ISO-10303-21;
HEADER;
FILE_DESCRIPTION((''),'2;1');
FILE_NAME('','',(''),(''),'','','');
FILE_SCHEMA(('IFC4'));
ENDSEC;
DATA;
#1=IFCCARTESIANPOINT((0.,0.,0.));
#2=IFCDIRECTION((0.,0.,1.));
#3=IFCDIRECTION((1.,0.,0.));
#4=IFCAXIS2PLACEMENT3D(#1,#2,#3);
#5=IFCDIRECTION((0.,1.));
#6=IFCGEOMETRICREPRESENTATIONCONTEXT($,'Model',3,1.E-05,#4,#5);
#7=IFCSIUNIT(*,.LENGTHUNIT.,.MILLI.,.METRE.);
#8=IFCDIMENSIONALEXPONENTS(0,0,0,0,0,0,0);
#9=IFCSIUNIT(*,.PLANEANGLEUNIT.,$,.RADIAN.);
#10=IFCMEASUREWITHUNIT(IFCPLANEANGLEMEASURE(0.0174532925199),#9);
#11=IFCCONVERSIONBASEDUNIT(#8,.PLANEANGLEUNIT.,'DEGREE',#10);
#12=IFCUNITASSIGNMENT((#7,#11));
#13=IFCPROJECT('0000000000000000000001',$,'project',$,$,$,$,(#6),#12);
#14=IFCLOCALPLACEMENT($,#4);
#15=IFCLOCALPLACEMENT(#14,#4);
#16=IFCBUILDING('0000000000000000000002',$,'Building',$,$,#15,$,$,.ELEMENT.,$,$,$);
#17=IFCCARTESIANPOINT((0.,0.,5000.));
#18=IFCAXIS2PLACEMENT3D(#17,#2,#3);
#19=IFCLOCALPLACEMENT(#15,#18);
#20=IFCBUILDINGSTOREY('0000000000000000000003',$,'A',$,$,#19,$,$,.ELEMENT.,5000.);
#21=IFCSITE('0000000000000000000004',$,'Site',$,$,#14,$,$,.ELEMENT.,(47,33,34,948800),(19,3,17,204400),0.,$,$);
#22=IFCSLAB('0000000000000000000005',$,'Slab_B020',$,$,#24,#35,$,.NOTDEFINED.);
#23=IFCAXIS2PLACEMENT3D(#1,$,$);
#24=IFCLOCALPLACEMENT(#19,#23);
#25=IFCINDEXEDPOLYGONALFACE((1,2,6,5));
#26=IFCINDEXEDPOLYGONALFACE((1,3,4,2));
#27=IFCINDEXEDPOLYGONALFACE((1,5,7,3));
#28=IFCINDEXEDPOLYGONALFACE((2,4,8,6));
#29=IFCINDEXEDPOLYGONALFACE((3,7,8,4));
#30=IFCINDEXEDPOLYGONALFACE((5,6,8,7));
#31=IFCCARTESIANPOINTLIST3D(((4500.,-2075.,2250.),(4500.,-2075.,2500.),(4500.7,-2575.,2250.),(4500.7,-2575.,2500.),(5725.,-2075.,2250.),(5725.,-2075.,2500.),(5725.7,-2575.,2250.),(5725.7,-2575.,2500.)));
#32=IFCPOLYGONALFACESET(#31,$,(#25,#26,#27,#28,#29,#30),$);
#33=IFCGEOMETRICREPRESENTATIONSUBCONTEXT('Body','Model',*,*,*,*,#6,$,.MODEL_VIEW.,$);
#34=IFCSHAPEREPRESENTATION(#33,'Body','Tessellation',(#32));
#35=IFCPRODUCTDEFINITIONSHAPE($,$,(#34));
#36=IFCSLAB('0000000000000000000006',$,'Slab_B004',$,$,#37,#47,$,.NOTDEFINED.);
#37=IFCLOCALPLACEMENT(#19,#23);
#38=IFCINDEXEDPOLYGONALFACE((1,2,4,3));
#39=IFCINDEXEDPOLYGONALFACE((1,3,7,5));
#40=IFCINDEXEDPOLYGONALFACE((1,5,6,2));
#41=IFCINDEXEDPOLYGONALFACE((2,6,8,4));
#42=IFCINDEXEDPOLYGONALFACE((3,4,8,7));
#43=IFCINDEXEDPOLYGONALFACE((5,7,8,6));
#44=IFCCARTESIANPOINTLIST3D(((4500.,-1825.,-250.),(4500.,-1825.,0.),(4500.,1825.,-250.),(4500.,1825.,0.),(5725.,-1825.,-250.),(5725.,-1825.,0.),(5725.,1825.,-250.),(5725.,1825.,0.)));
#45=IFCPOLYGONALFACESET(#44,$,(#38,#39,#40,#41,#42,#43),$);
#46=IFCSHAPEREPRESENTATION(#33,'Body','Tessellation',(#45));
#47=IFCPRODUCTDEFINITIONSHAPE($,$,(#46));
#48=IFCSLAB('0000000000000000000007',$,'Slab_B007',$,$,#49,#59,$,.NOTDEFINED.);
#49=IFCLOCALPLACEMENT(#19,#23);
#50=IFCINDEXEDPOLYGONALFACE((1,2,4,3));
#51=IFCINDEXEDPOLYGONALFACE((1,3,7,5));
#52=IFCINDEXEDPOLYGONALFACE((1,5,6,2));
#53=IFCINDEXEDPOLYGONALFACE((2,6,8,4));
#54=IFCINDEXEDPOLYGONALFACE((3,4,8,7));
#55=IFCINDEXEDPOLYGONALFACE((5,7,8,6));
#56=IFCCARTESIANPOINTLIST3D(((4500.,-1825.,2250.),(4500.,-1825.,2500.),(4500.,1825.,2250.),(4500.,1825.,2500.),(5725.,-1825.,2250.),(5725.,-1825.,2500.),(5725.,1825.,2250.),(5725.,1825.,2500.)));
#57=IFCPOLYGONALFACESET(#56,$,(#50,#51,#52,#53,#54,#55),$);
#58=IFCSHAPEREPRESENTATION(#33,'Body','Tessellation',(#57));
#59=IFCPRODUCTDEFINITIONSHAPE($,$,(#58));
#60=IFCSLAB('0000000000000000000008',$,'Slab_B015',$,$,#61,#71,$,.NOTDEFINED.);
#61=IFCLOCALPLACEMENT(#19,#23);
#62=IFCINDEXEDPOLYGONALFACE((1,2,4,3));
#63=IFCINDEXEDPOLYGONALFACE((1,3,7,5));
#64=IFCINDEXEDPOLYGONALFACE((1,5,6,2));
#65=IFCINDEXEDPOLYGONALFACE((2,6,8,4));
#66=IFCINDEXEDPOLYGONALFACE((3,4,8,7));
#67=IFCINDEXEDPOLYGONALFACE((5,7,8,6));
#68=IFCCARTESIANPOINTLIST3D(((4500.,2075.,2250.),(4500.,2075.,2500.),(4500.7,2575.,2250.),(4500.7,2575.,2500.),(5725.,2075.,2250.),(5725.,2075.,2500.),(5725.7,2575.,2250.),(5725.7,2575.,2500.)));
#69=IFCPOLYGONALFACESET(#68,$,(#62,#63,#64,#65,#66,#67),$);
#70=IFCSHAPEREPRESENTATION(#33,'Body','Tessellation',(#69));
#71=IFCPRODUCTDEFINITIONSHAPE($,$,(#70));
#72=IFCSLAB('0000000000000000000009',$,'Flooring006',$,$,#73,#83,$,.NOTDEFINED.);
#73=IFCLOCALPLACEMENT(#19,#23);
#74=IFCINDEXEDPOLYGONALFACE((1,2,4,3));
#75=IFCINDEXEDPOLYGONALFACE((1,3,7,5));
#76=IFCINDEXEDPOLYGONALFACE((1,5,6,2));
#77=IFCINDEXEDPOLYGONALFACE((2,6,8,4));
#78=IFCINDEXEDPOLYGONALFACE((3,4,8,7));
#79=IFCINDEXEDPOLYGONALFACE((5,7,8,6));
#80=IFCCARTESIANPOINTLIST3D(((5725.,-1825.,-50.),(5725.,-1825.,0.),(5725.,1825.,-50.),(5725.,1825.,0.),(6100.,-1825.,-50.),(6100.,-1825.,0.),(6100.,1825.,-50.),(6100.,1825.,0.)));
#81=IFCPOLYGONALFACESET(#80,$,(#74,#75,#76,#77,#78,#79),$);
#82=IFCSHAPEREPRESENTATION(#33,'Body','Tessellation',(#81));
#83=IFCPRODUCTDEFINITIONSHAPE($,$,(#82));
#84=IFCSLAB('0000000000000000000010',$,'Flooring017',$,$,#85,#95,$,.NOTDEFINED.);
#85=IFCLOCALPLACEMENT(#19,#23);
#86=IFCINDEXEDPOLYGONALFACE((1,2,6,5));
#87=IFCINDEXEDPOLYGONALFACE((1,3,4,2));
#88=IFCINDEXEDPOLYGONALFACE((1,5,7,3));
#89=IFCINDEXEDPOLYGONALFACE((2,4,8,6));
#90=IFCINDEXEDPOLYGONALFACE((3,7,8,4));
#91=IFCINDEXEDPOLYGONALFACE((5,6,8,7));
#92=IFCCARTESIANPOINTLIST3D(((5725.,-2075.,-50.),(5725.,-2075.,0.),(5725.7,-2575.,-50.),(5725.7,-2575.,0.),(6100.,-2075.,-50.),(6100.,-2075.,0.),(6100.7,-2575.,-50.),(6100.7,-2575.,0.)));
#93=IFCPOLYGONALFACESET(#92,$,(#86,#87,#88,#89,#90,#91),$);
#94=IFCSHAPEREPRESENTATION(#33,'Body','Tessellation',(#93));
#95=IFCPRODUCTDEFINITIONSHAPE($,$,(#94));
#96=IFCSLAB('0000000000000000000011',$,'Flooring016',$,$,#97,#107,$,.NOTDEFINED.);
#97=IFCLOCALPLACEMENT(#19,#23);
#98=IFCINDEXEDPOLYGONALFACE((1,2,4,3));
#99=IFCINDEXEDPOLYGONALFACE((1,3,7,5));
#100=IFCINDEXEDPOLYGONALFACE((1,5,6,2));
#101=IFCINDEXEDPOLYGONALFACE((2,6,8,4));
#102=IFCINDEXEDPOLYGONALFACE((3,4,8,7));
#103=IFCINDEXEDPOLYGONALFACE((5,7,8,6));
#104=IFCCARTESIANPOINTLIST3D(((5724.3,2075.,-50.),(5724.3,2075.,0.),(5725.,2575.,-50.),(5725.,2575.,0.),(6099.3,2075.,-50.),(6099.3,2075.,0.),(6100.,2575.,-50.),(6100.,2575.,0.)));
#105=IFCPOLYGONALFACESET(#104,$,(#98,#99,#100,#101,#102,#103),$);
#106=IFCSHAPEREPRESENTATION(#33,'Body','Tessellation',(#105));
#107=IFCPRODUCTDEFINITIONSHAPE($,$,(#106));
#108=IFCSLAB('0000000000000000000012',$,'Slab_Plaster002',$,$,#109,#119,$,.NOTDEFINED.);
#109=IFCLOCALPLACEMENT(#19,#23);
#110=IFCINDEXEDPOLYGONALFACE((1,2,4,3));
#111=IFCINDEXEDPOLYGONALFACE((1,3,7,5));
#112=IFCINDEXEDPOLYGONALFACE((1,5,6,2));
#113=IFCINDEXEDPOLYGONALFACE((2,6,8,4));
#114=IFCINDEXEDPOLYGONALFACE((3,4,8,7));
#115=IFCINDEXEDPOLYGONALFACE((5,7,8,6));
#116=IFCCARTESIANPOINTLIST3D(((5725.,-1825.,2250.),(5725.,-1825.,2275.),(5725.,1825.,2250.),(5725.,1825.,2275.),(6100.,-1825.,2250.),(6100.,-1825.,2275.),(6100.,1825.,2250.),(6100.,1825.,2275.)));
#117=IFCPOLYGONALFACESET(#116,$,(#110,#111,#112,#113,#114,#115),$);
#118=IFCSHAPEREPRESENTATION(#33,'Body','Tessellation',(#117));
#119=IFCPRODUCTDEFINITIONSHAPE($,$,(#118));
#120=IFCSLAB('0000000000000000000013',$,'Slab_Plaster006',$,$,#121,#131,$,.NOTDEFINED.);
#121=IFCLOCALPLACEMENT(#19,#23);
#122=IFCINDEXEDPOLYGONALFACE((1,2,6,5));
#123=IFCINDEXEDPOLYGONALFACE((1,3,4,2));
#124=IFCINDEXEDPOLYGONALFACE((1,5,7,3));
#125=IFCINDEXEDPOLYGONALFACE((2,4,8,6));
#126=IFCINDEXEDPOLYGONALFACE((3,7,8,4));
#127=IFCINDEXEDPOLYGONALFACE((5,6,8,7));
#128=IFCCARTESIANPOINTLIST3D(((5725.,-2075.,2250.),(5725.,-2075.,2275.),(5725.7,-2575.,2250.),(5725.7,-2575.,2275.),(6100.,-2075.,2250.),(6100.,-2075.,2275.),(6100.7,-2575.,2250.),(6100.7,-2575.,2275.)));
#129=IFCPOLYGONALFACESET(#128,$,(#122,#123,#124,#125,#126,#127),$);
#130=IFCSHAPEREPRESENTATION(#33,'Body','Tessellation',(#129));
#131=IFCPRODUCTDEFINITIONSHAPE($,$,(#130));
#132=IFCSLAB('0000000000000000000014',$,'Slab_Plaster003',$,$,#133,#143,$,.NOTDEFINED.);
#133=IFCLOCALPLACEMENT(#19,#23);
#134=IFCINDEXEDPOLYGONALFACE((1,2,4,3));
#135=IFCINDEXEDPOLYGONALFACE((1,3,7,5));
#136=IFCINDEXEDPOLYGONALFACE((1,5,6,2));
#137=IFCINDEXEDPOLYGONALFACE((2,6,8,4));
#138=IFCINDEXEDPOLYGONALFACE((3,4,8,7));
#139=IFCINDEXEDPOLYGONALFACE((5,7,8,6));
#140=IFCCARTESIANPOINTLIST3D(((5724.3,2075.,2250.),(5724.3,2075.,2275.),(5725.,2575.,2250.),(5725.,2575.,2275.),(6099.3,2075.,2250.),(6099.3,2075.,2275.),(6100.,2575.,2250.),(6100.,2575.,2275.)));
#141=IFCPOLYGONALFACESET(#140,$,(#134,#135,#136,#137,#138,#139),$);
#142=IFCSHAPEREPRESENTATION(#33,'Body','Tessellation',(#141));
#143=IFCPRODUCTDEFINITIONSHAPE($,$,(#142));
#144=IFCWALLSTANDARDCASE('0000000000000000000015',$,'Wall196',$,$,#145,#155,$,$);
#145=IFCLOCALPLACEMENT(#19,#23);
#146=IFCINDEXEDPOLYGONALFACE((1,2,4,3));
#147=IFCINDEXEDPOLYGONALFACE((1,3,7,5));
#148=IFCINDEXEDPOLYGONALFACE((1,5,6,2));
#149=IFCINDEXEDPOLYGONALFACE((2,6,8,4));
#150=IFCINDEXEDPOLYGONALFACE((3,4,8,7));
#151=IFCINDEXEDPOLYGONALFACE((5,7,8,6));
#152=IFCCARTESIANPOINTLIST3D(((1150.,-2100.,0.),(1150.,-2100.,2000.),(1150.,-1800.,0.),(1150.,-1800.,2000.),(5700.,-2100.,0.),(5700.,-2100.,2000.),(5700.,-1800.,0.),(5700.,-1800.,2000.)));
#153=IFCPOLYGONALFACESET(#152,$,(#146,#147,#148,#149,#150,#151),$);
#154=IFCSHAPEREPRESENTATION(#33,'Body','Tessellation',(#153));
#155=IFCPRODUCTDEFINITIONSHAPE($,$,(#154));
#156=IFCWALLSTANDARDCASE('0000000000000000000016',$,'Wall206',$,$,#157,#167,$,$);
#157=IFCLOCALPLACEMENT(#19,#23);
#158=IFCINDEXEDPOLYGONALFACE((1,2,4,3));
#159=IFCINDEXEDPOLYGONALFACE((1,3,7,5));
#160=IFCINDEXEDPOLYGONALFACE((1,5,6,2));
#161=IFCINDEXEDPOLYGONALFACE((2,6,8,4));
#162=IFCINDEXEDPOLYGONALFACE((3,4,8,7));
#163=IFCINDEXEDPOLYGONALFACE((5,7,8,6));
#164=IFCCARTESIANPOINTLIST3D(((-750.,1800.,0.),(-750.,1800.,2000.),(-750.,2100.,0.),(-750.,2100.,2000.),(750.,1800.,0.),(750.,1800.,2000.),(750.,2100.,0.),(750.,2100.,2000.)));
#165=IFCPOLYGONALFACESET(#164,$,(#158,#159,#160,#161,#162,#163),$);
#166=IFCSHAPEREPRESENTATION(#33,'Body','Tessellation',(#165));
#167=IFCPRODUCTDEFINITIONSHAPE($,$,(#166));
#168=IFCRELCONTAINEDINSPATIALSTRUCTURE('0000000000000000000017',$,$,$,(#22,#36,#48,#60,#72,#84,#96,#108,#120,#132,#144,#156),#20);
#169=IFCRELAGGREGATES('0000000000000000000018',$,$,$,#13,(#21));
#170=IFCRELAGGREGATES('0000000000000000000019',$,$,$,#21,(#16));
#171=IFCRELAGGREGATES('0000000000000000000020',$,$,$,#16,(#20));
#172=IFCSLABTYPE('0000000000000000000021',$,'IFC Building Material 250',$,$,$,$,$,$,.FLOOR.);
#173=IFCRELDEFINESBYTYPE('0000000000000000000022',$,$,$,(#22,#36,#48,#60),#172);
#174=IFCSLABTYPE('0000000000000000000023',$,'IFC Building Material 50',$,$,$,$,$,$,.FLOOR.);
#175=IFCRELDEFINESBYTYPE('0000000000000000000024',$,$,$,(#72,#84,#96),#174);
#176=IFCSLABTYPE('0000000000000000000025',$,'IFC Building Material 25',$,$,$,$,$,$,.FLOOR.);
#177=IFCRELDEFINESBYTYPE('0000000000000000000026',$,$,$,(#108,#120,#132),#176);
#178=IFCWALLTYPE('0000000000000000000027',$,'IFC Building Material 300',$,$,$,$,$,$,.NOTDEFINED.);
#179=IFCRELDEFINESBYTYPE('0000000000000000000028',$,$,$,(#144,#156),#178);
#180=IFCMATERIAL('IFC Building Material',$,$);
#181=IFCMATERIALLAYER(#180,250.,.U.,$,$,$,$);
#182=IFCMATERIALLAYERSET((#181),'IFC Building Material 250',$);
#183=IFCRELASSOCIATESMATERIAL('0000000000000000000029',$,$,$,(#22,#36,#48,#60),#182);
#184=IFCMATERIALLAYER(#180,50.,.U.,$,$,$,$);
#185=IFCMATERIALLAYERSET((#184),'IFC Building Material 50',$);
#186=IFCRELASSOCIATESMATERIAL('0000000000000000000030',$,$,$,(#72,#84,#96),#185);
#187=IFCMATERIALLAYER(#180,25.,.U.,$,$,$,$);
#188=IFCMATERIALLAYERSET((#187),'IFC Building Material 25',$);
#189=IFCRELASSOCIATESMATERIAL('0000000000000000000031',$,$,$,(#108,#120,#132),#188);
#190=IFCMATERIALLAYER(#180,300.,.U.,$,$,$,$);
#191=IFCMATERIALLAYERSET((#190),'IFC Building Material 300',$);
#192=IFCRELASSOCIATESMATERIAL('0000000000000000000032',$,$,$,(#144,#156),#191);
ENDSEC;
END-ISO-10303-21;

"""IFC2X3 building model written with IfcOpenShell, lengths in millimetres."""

from ifc_helpers import new_model, entity, si_unit, converted_unit, direction, frame, origin_with_axes, place, context, subcontext, project, spatial, polyline, outline, extrude, material, layer, layer_set, layer_usage, type_object, element, save


model = new_model("IFC2X3")

# Units and contexts
model_context = context("Model", 3, precision=1e-05, world=origin_with_axes(), true_north=direction((0.0, 1.0)))
body_context = subcontext(model_context, "Body", "Model", "MODEL_VIEW")
ifc_project = project(units=[si_unit("LENGTHUNIT", "METRE", prefix="MILLI"), converted_unit("PLANEANGLEUNIT", "DEGREE", entity("IfcPlaneAngleMeasure", 0.0174532925199), si_unit("PLANEANGLEUNIT", "RADIAN"), dimensions=[0, 0, 0, 0, 0, 0, 0])], contexts=[model_context])

# Site, building, storey
site_placement = place(None, origin_with_axes())
site = spatial("IfcSite", under=ifc_project, at=site_placement, Name="Site", CompositionType="ELEMENT", RefLatitude=(47, 33, 34, 948800), RefLongitude=(19, 3, 17, 204400), RefElevation=0.0)
building_placement = place(site_placement, origin_with_axes())
building = spatial("IfcBuilding", under=site, at=building_placement, Name="Building", CompositionType="ELEMENT")
storey_placement = place(building_placement, frame((0.0, 0.0, 5000.0), z_axis=(0.0, 0.0, 1.0), x_axis=(1.0, 0.0, 0.0)))
storey = spatial("IfcBuildingStorey", under=building, at=storey_placement, Name="A", CompositionType="ELEMENT", Elevation=5000.0)

# Shared definitions
ifc_material = material(Name="IFC Building Material")

# Slabs
ifc_layer_1 = layer(ifc_material, 250.0, ventilated="UNKNOWN")
ifc_layer_set_1 = layer_set([ifc_layer_1], Name="IFC Building Material 250")
slab_type_1 = type_object("IfcSlabType", Name="IFC Building Material 250", PredefinedType="FLOOR")
ifc_layer_usage_1 = layer_usage(ifc_layer_set_1, "AXIS3", "NEGATIVE", 250.0)
slab_1_placement = place(storey_placement, frame((4500.0, -2075.0, 2500.0), z_axis=(0.0, 0.0, 1.0), x_axis=(1.0, 0.0, 0.0)))
element("IfcSlab", 1, at=slab_1_placement, inside=storey, type_object=slab_type_1, material=ifc_layer_usage_1, Name="Slab_B020", PredefinedType="NOTDEFINED", context=body_context, shape_type="SweptSolid", body=[
    extrude(outline(polyline([(0.0, 0.0), (0.7, -500.0), (1225.7, -500.0), (1225.0, 0.0), (0.0, 0.0)])), frame((0.0, 0.0, -250.0), z_axis=(0.0, 0.0, 1.0), x_axis=(1.0, 0.0, 0.0)), (0.0, 0.0, 1.0), 250.0),
])
ifc_layer_usage_2 = layer_usage(ifc_layer_set_1, "AXIS3", "NEGATIVE", 250.0)
slab_2_placement = place(storey_placement, frame((4500.0, 1825.0, 0.0), z_axis=(0.0, 0.0, 1.0), x_axis=(1.0, 0.0, 0.0)))
element("IfcSlab", 2, at=slab_2_placement, inside=storey, type_object=slab_type_1, material=ifc_layer_usage_2, Name="Slab_B004", PredefinedType="NOTDEFINED", context=body_context, shape_type="SweptSolid", body=[
    extrude(outline(polyline([(0.0, 0.0), (0.0, -3650.0), (1225.0, -3650.0), (1225.0, 0.0), (0.0, 0.0)])), frame((0.0, 0.0, -250.0), z_axis=(0.0, 0.0, 1.0), x_axis=(1.0, 0.0, 0.0)), (0.0, 0.0, 1.0), 250.0),
])
ifc_layer_usage_3 = layer_usage(ifc_layer_set_1, "AXIS3", "NEGATIVE", 250.0)
slab_3_placement = place(storey_placement, frame((4500.0, 1825.0, 2500.0), z_axis=(0.0, 0.0, 1.0), x_axis=(1.0, 0.0, 0.0)))
element("IfcSlab", 3, at=slab_3_placement, inside=storey, type_object=slab_type_1, material=ifc_layer_usage_3, Name="Slab_B007", PredefinedType="NOTDEFINED", context=body_context, shape_type="SweptSolid", body=[
    extrude(outline(polyline([(0.0, 0.0), (0.0, -3650.0), (1225.0, -3650.0), (1225.0, 0.0), (0.0, 0.0)])), frame((0.0, 0.0, -250.0), z_axis=(0.0, 0.0, 1.0), x_axis=(1.0, 0.0, 0.0)), (0.0, 0.0, 1.0), 250.0),
])
ifc_layer_usage_4 = layer_usage(ifc_layer_set_1, "AXIS3", "NEGATIVE", 250.0)
slab_4_placement = place(storey_placement, frame((4500.0, 2075.0, 2500.0), z_axis=(0.0, 0.0, 1.0), x_axis=(1.0, 0.0, 0.0)))
element("IfcSlab", 4, at=slab_4_placement, inside=storey, type_object=slab_type_1, material=ifc_layer_usage_4, Name="Slab_B015", PredefinedType="NOTDEFINED", context=body_context, shape_type="SweptSolid", body=[
    extrude(outline(polyline([(0.0, 0.0), (1225.0, 0.0), (1225.7, 500.0), (0.7, 500.0), (0.0, 0.0)])), frame((0.0, 0.0, -250.0), z_axis=(0.0, 0.0, 1.0), x_axis=(1.0, 0.0, 0.0)), (0.0, 0.0, 1.0), 250.0),
])
ifc_layer_2 = layer(ifc_material, 50.0, ventilated="UNKNOWN")
ifc_layer_set_2 = layer_set([ifc_layer_2], Name="IFC Building Material 50")
ifc_layer_usage_5 = layer_usage(ifc_layer_set_2, "AXIS3", "NEGATIVE", 50.0)
slab_type_2 = type_object("IfcSlabType", Name="IFC Building Material 50", PredefinedType="FLOOR")
slab_5_placement = place(storey_placement, frame((5725.0, -1825.0, 0.0), z_axis=(0.0, 0.0, 1.0), x_axis=(1.0, 0.0, 0.0)))
element("IfcSlab", 5, at=slab_5_placement, inside=storey, type_object=slab_type_2, material=ifc_layer_usage_5, Name="Flooring006", PredefinedType="NOTDEFINED", context=body_context, shape_type="SweptSolid", body=[
    extrude(outline(polyline([(0.0, 0.0), (375.0, 0.0), (375.0, 3650.0), (0.0, 3650.0), (0.0, 0.0)])), frame((0.0, 0.0, -50.0), z_axis=(0.0, 0.0, 1.0), x_axis=(1.0, 0.0, 0.0)), (0.0, 0.0, 1.0), 50.0),
])
ifc_layer_usage_6 = layer_usage(ifc_layer_set_2, "AXIS3", "NEGATIVE", 50.0)
slab_6_placement = place(storey_placement, frame((5725.7, -2575.0, 0.0), z_axis=(0.0, 0.0, 1.0), x_axis=(1.0, 0.0, 0.0)))
element("IfcSlab", 6, at=slab_6_placement, inside=storey, type_object=slab_type_2, material=ifc_layer_usage_6, Name="Flooring017", PredefinedType="NOTDEFINED", context=body_context, shape_type="SweptSolid", body=[
    extrude(outline(polyline([(0.0, 0.0), (375.0, 0.0), (374.3, 500.0), (-0.7, 500.0), (0.0, 0.0)])), frame((0.0, 0.0, -50.0), z_axis=(0.0, 0.0, 1.0), x_axis=(1.0, 0.0, 0.0)), (0.0, 0.0, 1.0), 50.0),
])
ifc_layer_usage_7 = layer_usage(ifc_layer_set_2, "AXIS3", "NEGATIVE", 50.0)
slab_7_placement = place(storey_placement, frame((5725.0, 2575.0, 0.0), z_axis=(0.0, 0.0, 1.0), x_axis=(1.0, 0.0, 0.0)))
element("IfcSlab", 7, at=slab_7_placement, inside=storey, type_object=slab_type_2, material=ifc_layer_usage_7, Name="Flooring016", PredefinedType="NOTDEFINED", context=body_context, shape_type="SweptSolid", body=[
    extrude(outline(polyline([(0.0, 0.0), (-0.7, -500.0), (374.3, -500.0), (375.0, 0.0), (0.0, 0.0)])), frame((0.0, 0.0, -50.0), z_axis=(0.0, 0.0, 1.0), x_axis=(1.0, 0.0, 0.0)), (0.0, 0.0, 1.0), 50.0),
])
ifc_layer_3 = layer(ifc_material, 25.0, ventilated="UNKNOWN")
ifc_layer_set_3 = layer_set([ifc_layer_3], Name="IFC Building Material 25")
ifc_layer_usage_8 = layer_usage(ifc_layer_set_3, "AXIS3", "NEGATIVE", 25.0)
slab_type_3 = type_object("IfcSlabType", Name="IFC Building Material 25", PredefinedType="FLOOR")
slab_8_placement = place(storey_placement, frame((5725.0, -1825.0, 2275.0), z_axis=(0.0, 0.0, 1.0), x_axis=(1.0, 0.0, 0.0)))
element("IfcSlab", 8, at=slab_8_placement, inside=storey, type_object=slab_type_3, material=ifc_layer_usage_8, Name="Slab_Plaster002", PredefinedType="NOTDEFINED", context=body_context, shape_type="SweptSolid", body=[
    extrude(outline(polyline([(0.0, 0.0), (375.0, 0.0), (375.0, 3650.0), (0.0, 3650.0), (0.0, 0.0)])), frame((0.0, 0.0, -25.0), z_axis=(0.0, 0.0, 1.0), x_axis=(1.0, 0.0, 0.0)), (0.0, 0.0, 1.0), 25.0),
])
ifc_layer_usage_9 = layer_usage(ifc_layer_set_3, "AXIS3", "NEGATIVE", 25.0)
slab_9_placement = place(storey_placement, frame((5725.7, -2575.0, 2275.0), z_axis=(0.0, 0.0, 1.0), x_axis=(1.0, 0.0, 0.0)))
element("IfcSlab", 9, at=slab_9_placement, inside=storey, type_object=slab_type_3, material=ifc_layer_usage_9, Name="Slab_Plaster006", PredefinedType="NOTDEFINED", context=body_context, shape_type="SweptSolid", body=[
    extrude(outline(polyline([(0.0, 0.0), (375.0, 0.0), (374.3, 500.0), (-0.7, 500.0), (0.0, 0.0)])), frame((0.0, 0.0, -25.0), z_axis=(0.0, 0.0, 1.0), x_axis=(1.0, 0.0, 0.0)), (0.0, 0.0, 1.0), 25.0),
])
ifc_layer_usage_10 = layer_usage(ifc_layer_set_3, "AXIS3", "NEGATIVE", 25.0)
slab_10_placement = place(storey_placement, frame((5725.0, 2575.0, 2275.0), z_axis=(0.0, 0.0, 1.0), x_axis=(1.0, 0.0, 0.0)))
element("IfcSlab", 10, at=slab_10_placement, inside=storey, type_object=slab_type_3, material=ifc_layer_usage_10, Name="Slab_Plaster003", PredefinedType="NOTDEFINED", context=body_context, shape_type="SweptSolid", body=[
    extrude(outline(polyline([(0.0, 0.0), (-0.7, -500.0), (374.3, -500.0), (375.0, 0.0), (0.0, 0.0)])), frame((0.0, 0.0, -25.0), z_axis=(0.0, 0.0, 1.0), x_axis=(1.0, 0.0, 0.0)), (0.0, 0.0, 1.0), 25.0),
])

# Walls
ifc_layer_4 = layer(ifc_material, 300.0, ventilated="UNKNOWN")
ifc_layer_set_4 = layer_set([ifc_layer_4], Name="IFC Building Material 300")
ifc_layer_usage_11 = layer_usage(ifc_layer_set_4, "AXIS2", "POSITIVE", 0.0)
wall_type_1 = type_object("IfcWallType", Name="IFC Building Material 300", PredefinedType="NOTDEFINED")
wall_1_placement = place(storey_placement, frame((5700.0, -1800.0, 0.0), z_axis=(0.0, 0.0, 1.0), x_axis=(-1.0, 0.0, 0.0)))
element("IfcWallStandardCase", 11, at=wall_1_placement, inside=storey, type_object=wall_type_1, material=ifc_layer_usage_11, Name="Wall196", context=body_context, shape_type="SweptSolid", body=[
    extrude(outline(polyline([(0.0, 0.0), (4550.0, 0.0), (4550.0, 300.0), (0.0, 300.0), (0.0, 0.0)])), origin_with_axes(), (0.0, 0.0, 1.0), 2000.0),
])
ifc_layer_usage_12 = layer_usage(ifc_layer_set_4, "AXIS2", "POSITIVE", 0.0)
wall_2_placement = place(storey_placement, frame((-750.0, 1800.0, 0.0), z_axis=(0.0, 0.0, 1.0), x_axis=(1.0, 0.0, 0.0)))
element("IfcWallStandardCase", 12, at=wall_2_placement, inside=storey, type_object=wall_type_1, material=ifc_layer_usage_12, Name="Wall206", context=body_context, shape_type="SweptSolid", body=[
    extrude(outline(polyline([(0.0, 0.0), (1500.0, 0.0), (1500.0, 300.0), (0.0, 300.0), (0.0, 0.0)])), origin_with_axes(), (0.0, 0.0, 1.0), 2000.0),
])

save(model, "model.ifc")
